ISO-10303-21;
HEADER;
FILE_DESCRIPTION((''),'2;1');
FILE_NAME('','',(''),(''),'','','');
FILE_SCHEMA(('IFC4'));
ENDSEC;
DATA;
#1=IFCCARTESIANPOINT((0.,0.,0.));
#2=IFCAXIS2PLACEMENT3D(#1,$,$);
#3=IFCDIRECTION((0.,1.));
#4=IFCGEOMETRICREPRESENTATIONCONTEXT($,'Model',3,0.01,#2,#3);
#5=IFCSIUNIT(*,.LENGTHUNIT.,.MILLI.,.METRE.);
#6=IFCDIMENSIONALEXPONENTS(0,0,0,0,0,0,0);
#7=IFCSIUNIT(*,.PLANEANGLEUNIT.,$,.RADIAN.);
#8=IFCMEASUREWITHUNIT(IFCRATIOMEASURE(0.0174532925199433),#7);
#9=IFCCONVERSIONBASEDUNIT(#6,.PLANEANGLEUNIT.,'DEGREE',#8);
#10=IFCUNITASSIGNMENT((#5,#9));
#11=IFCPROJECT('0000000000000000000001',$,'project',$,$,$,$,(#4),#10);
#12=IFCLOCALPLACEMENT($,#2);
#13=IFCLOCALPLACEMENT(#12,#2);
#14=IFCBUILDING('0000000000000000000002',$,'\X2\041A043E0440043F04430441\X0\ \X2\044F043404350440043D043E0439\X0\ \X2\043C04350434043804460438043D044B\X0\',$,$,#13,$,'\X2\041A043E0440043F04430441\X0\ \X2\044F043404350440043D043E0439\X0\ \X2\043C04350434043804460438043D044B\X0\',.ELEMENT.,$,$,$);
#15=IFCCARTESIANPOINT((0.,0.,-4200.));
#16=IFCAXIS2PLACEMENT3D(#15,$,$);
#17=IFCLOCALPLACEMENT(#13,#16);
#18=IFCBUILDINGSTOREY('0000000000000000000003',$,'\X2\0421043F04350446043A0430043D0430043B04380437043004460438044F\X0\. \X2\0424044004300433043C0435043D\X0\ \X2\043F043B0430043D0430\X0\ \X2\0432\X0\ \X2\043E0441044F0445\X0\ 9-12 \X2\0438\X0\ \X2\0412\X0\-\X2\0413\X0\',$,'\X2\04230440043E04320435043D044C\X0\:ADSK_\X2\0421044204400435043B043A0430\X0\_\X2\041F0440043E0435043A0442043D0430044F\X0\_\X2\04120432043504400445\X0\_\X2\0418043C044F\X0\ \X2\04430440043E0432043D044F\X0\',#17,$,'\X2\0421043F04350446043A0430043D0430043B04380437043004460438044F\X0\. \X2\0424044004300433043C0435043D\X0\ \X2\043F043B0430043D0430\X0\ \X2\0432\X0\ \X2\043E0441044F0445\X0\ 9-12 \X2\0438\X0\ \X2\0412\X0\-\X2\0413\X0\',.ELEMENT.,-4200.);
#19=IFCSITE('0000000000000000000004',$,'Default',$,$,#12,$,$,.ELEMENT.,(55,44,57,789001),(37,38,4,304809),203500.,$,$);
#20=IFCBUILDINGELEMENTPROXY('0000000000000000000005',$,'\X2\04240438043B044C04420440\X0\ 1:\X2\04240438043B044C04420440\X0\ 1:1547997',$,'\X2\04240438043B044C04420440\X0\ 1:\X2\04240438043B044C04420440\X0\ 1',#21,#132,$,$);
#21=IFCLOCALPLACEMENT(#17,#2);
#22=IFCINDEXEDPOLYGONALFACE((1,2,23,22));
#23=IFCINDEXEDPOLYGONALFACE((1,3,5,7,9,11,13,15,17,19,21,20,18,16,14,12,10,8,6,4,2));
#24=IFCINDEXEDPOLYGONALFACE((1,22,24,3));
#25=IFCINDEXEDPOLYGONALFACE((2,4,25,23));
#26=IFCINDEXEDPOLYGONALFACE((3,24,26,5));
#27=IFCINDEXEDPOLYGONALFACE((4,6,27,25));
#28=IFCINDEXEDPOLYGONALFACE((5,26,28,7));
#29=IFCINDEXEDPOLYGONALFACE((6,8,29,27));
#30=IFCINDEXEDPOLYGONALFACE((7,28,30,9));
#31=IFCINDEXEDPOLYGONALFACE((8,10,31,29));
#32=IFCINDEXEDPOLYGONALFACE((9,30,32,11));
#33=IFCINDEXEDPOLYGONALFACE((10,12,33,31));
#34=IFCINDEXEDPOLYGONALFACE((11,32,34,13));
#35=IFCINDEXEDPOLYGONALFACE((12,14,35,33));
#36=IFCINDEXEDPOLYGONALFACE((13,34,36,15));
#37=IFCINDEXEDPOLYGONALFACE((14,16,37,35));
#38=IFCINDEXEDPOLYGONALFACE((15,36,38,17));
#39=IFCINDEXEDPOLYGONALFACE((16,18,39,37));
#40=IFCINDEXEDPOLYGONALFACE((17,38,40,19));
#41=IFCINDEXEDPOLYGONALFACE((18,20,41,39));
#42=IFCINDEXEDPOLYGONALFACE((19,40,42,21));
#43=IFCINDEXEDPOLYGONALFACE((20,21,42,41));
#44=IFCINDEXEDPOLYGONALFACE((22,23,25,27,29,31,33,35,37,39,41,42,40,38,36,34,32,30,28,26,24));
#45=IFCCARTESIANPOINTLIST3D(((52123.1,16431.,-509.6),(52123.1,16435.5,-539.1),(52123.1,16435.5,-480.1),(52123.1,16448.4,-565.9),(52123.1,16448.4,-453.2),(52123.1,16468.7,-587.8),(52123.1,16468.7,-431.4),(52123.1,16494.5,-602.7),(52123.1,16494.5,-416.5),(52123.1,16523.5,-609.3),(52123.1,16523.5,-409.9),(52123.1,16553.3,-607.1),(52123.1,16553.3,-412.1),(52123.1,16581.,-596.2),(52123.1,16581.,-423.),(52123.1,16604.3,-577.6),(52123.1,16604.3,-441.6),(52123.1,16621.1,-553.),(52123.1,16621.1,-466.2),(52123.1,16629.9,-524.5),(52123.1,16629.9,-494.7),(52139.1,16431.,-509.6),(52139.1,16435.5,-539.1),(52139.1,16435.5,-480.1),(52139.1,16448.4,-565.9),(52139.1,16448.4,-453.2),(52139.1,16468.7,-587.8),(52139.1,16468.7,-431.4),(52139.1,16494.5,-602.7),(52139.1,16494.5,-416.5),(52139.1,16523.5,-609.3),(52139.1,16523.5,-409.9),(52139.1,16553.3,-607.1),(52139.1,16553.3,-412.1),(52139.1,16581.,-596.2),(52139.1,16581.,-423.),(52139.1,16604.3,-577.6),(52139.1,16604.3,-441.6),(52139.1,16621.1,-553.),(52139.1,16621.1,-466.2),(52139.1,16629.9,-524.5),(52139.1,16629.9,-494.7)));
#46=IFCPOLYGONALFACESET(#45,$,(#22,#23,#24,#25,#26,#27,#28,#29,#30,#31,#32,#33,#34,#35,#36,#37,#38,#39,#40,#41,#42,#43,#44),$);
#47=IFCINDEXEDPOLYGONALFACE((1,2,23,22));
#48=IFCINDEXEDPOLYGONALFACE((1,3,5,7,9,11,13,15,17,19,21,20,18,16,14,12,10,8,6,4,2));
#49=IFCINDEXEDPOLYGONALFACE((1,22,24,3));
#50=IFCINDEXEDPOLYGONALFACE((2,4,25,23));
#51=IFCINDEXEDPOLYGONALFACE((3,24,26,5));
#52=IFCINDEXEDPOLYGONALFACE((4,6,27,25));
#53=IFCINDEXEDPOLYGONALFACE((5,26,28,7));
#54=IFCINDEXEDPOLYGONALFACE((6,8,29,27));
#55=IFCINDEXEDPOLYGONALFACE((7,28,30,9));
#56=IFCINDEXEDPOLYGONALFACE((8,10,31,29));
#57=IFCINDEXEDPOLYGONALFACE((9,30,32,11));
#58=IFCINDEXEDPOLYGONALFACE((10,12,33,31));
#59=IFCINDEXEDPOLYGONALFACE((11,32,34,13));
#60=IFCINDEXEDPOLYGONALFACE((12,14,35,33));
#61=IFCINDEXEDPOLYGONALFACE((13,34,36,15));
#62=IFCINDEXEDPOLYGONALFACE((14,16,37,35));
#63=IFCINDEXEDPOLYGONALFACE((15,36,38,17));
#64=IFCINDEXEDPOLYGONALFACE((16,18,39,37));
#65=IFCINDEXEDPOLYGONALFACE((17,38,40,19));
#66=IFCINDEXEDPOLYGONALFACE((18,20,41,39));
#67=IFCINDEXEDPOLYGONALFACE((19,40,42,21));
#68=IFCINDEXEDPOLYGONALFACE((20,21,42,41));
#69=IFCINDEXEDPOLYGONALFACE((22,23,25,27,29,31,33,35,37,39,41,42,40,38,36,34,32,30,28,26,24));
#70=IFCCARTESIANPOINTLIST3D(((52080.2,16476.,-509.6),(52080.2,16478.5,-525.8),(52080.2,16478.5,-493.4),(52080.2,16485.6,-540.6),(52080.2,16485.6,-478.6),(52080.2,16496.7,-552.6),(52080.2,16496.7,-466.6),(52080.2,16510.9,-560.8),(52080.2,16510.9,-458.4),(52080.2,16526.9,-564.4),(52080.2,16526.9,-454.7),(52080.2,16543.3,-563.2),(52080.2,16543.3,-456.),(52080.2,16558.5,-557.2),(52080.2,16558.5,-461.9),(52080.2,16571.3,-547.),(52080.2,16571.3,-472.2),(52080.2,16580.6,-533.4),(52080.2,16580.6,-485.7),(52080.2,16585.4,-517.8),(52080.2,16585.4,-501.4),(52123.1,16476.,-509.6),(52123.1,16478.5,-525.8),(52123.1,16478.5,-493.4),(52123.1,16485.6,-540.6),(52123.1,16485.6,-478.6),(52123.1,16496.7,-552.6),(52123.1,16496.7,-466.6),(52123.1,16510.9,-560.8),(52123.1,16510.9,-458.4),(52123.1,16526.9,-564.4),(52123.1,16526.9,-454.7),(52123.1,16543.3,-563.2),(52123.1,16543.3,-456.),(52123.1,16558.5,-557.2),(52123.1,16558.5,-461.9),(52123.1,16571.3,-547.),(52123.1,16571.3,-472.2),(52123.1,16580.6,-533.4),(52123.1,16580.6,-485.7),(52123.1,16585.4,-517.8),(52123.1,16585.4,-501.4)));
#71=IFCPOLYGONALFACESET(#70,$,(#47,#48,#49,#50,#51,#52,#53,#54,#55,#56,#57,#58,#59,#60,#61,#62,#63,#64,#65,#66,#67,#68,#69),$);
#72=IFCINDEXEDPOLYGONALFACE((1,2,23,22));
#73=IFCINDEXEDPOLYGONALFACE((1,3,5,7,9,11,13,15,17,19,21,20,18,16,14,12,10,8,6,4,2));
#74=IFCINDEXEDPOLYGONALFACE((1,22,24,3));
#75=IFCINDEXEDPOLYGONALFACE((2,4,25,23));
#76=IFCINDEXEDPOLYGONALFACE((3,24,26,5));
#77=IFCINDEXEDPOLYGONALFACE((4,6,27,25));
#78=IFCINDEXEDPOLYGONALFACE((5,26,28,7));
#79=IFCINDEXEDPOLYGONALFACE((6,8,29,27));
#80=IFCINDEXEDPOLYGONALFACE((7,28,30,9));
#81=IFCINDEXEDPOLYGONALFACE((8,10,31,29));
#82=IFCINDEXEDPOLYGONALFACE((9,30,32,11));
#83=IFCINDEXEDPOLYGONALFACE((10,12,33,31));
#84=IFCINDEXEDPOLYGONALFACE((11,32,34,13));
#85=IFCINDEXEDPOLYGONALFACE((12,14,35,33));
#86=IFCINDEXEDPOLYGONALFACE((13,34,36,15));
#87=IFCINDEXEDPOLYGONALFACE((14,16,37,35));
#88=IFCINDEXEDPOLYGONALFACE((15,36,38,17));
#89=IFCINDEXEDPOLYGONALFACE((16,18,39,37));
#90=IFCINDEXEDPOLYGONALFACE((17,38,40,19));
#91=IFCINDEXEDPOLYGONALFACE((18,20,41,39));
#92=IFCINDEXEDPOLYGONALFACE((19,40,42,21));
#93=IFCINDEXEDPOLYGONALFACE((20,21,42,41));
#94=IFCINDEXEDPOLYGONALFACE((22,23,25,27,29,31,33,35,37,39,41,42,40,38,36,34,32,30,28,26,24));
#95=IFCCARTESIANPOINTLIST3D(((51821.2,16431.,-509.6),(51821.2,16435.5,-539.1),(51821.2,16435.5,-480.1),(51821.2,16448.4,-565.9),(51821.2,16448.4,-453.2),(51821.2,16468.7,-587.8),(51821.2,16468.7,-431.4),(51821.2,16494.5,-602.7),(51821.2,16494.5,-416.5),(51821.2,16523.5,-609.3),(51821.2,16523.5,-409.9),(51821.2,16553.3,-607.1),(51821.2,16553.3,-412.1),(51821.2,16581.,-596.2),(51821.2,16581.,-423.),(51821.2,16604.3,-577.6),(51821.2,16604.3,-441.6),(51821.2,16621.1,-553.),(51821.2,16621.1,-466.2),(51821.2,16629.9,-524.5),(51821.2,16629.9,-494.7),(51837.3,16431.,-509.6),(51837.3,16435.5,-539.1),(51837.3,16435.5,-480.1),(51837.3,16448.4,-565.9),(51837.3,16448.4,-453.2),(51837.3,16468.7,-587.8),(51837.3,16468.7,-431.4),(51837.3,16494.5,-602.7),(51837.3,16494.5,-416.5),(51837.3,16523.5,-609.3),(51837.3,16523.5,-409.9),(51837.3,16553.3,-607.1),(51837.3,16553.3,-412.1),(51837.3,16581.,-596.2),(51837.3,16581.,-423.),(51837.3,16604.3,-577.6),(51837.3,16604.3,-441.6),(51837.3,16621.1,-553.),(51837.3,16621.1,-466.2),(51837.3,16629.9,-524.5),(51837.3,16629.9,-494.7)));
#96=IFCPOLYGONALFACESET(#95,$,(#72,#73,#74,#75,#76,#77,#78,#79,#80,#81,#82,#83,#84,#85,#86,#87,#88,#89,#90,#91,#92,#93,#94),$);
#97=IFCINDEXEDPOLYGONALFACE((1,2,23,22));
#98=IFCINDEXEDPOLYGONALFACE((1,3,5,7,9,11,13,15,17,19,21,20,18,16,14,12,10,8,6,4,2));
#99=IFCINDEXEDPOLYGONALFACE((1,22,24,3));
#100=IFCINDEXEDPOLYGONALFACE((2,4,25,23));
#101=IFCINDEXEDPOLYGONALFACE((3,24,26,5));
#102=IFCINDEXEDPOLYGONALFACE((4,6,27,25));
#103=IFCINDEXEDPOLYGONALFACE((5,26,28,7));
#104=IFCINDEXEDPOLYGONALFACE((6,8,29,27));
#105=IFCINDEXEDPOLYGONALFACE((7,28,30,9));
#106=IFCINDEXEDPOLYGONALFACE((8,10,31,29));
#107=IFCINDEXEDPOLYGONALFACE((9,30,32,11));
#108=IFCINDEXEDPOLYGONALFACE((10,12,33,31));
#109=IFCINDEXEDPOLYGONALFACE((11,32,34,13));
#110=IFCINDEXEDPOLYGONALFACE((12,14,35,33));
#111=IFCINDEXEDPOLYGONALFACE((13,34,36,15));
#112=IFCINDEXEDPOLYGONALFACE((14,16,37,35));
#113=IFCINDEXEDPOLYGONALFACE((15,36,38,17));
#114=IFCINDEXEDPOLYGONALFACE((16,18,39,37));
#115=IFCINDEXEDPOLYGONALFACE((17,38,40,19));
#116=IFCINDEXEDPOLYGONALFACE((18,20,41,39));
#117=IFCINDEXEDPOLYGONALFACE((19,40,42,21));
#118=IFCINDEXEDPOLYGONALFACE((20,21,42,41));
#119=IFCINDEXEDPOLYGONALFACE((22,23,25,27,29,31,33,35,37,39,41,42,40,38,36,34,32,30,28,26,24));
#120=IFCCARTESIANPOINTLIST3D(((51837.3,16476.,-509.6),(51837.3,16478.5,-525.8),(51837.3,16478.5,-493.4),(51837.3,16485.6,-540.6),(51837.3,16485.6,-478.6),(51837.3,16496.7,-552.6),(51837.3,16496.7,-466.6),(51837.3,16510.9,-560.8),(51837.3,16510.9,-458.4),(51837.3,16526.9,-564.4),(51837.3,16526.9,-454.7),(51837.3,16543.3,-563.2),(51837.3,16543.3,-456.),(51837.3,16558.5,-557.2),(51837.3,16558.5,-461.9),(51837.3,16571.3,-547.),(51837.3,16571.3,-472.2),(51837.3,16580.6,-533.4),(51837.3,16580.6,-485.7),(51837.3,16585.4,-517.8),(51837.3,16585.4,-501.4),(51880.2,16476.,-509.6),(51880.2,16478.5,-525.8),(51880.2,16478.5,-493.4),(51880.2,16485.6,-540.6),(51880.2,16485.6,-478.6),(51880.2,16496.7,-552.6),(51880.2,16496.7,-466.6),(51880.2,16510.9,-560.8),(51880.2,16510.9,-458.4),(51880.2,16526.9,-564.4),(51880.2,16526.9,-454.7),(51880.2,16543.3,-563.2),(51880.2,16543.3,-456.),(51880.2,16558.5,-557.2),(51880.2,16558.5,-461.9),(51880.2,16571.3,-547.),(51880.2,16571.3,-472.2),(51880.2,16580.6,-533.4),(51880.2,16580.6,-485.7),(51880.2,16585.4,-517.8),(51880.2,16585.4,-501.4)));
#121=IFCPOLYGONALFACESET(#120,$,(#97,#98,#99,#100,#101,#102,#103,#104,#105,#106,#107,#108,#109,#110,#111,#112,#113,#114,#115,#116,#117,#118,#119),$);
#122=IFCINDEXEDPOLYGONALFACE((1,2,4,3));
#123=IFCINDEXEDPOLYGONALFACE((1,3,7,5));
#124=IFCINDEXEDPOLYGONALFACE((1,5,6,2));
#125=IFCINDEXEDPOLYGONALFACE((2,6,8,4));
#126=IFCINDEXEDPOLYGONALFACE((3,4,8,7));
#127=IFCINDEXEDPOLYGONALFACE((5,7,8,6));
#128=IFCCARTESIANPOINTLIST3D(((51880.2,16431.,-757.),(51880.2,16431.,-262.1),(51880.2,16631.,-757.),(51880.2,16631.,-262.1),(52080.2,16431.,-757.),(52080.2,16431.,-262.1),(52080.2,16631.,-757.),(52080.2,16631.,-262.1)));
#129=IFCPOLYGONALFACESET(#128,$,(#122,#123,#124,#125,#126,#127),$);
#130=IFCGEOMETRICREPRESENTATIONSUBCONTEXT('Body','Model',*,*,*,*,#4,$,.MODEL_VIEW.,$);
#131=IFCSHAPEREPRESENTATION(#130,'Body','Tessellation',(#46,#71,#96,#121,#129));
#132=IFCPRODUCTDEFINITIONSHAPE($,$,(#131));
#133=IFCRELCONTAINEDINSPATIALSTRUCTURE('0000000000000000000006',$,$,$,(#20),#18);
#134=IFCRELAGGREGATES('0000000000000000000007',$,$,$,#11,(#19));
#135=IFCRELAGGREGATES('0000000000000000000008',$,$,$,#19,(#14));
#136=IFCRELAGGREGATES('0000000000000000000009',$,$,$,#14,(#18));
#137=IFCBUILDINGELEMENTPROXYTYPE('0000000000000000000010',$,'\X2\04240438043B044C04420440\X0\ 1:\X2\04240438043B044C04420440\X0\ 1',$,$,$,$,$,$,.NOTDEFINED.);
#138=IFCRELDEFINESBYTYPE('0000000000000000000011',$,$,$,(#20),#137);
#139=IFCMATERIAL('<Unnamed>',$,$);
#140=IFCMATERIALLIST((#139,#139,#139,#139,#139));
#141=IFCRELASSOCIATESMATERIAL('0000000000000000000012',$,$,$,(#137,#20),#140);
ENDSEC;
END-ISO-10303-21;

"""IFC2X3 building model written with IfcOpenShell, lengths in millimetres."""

from ifc_helpers import new_model, entity, si_unit, converted_unit, direction, frame, origin, origin_2d_with_axis, place, context, subcontext, project, spatial, rectangle, circle, extrude, source, transform, mapped, material, material_list, type_object, type_shapes, element, save


model = new_model("IFC2X3")

# Units and contexts
model_context = context("Model", 3, precision=0.01, world=origin(), true_north=direction((0.0, 1.0)))
body_context = subcontext(model_context, "Body", "Model", "MODEL_VIEW")
ifc_project = project(units=[si_unit("LENGTHUNIT", "METRE", prefix="MILLI"), converted_unit("PLANEANGLEUNIT", "DEGREE", entity("IfcRatioMeasure", 0.0174532925199433), si_unit("PLANEANGLEUNIT", "RADIAN"), dimensions=[0, 0, 0, 0, 0, 0, 0])], contexts=[model_context])

# Site, building, storey
site_placement = place(None, origin())
site = spatial("IfcSite", under=ifc_project, at=site_placement, Name="Default", CompositionType="ELEMENT", RefLatitude=(55, 44, 57, 789001), RefLongitude=(37, 38, 4, 304809), RefElevation=203500.0)
building_placement = place(site_placement, origin())
building = spatial("IfcBuilding", under=site, at=building_placement, Name="Корпус ядерной медицины", LongName="Корпус ядерной медицины", CompositionType="ELEMENT")
storey_placement = place(building_placement, frame((0.0, 0.0, -4200.0)))
storey = spatial("IfcBuildingStorey", under=building, at=storey_placement, Name="Спецканализация. Фрагмен плана в осях 9-12 и В-Г", ObjectType="Уровень:ADSK_Стрелка_Проектная_Вверх_Имя уровня", LongName="Спецканализация. Фрагмен плана в осях 9-12 и В-Г", CompositionType="ELEMENT", Elevation=-4200.0)

# Building element proxy
ifc_material_1 = material(Name="<Unnamed>")
ifc_material_list_1 = material_list([ifc_material_1, ifc_material_1, ifc_material_1, ifc_material_1, ifc_material_1])
building_element_proxy_type_1 = type_object("IfcBuildingElementProxyType", Name="Фильтр 1:Фильтр 1", PredefinedType="NOTDEFINED", material=ifc_material_list_1)
shared_shape_1 = source(origin(), body_context, "Body", "SweptSolid", [
    extrude(circle(Radius=100.0, at=origin_2d_with_axis()), frame((142.9, 0.0, 89.7), z_axis=(1.0, 0.0, 0.0), x_axis=(0.0, -1.0, 0.0)), (0.0, 0.0, 1.0), 16.1),
    extrude(circle(Radius=55.0, at=origin_2d_with_axis()), frame((100.0, 0.0, 89.7), z_axis=(1.0, 0.0, 0.0), x_axis=(0.0, -1.0, 0.0)), (0.0, 0.0, 1.0), 42.9),
    extrude(circle(Radius=100.0, at=origin_2d_with_axis()), frame((-158.9, 0.0, 89.7), z_axis=(1.0, 0.0, 0.0), x_axis=(0.0, -1.0, 0.0)), (0.0, 0.0, 1.0), 16.1),
    extrude(circle(Radius=55.0, at=origin_2d_with_axis()), frame((-142.9, 0.0, 89.7), z_axis=(1.0, 0.0, 0.0), x_axis=(0.0, -1.0, 0.0)), (0.0, 0.0, 1.0), 42.9),
    extrude(rectangle(XDim=200.0, YDim=200.0, at=origin_2d_with_axis()), frame((0.0, 0.0, -157.8), z_axis=(0.0, 0.0, 1.0), x_axis=(0.0, -1.0, 0.0)), (0.0, 0.0, 1.0), 494.9),
])
type_shapes(building_element_proxy_type_1, [shared_shape_1])
proxy_1_placement = place(storey_placement, frame((51980.2, 16531.0, -599.2)))
element("IfcBuildingElementProxy", 1, at=proxy_1_placement, inside=storey, type_object=building_element_proxy_type_1, material=ifc_material_list_1, Name="Фильтр 1:Фильтр 1:1547997", ObjectType="Фильтр 1:Фильтр 1", context=body_context, shape_type="MappedRepresentation", body=[
    mapped(shared_shape_1, transform((0.0, 0.0, 0.0), scale=1.0)),
])

save(model, "model.ifc")
